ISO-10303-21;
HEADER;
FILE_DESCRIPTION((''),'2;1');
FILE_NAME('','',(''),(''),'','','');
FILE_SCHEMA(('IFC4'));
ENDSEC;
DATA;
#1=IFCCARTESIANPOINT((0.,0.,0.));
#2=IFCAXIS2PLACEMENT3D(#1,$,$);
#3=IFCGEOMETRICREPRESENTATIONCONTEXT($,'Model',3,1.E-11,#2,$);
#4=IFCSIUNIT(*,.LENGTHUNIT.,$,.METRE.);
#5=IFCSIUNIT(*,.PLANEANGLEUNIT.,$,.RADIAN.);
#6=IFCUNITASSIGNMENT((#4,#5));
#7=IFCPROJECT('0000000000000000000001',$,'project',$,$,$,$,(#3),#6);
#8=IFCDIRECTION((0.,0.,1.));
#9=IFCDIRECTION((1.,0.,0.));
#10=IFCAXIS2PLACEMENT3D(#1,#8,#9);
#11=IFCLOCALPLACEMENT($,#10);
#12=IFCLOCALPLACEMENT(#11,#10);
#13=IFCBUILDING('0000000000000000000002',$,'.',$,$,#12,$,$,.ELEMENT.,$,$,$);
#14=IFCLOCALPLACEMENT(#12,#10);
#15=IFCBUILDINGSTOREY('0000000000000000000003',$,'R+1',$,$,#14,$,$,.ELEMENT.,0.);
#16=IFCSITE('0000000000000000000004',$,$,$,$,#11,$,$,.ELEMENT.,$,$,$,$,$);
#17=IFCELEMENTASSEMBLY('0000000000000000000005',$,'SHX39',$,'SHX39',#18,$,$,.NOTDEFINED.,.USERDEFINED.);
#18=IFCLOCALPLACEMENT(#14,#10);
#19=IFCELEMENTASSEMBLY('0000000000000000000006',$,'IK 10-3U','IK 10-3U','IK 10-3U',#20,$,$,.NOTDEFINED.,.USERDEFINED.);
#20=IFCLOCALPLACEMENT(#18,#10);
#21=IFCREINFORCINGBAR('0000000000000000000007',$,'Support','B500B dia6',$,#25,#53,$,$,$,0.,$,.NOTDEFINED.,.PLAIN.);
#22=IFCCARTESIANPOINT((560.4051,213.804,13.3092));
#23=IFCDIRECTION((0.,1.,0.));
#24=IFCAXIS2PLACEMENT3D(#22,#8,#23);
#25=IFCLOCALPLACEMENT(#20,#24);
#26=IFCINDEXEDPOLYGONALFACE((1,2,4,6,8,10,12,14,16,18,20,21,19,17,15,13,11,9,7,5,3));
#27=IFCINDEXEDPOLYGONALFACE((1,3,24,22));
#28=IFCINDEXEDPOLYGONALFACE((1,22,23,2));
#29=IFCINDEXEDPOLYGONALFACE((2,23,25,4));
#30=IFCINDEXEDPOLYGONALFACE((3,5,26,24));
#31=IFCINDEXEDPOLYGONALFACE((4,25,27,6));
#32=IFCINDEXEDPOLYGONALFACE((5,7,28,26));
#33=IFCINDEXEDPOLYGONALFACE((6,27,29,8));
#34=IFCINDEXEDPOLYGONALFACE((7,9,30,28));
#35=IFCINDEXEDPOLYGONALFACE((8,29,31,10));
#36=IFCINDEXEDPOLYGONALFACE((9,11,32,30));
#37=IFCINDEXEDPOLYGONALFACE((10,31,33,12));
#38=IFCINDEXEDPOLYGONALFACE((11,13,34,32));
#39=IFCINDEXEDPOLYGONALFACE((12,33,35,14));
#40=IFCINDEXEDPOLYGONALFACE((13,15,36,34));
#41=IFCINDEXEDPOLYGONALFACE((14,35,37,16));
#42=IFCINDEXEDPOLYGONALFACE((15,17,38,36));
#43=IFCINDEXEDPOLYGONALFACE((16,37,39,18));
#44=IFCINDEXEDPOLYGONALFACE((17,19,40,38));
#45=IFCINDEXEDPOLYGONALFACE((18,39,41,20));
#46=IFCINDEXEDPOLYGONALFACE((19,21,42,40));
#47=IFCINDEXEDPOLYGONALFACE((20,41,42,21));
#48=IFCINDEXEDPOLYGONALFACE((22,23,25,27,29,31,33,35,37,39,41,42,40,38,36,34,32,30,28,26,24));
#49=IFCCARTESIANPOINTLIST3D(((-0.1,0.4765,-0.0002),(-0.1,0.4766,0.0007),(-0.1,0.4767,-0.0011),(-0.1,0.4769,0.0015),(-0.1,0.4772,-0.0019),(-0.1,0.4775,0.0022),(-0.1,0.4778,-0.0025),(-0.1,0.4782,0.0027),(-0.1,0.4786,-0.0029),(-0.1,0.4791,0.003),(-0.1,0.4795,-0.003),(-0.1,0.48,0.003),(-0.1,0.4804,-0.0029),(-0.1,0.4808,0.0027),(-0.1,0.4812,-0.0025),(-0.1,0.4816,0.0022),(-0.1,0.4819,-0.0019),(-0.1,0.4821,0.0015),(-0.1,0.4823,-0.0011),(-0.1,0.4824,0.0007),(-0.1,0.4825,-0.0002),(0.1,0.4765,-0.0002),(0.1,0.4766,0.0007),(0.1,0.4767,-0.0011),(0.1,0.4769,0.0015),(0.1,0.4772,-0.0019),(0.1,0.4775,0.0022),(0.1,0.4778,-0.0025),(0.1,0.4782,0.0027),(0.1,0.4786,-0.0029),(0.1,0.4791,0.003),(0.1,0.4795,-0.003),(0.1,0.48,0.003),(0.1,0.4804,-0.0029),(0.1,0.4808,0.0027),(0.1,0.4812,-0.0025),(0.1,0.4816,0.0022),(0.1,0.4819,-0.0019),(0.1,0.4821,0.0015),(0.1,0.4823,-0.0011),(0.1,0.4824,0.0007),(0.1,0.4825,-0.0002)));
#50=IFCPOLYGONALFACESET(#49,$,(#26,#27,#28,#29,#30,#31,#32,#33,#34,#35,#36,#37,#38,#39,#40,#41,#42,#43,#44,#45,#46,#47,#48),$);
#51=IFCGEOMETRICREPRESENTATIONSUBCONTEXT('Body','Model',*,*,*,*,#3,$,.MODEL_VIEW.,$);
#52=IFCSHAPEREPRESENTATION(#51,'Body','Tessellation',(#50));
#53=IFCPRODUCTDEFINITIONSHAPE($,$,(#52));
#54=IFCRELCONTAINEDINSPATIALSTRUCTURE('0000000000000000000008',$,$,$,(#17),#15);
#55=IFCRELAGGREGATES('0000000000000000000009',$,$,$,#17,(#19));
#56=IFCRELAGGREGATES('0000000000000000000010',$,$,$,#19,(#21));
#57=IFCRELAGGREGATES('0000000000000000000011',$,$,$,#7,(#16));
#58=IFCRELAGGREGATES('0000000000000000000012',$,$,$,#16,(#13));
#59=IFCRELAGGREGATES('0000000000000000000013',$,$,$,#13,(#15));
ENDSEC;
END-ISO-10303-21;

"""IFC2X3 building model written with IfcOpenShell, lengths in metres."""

from ifc_helpers import new_model, entity, si_unit, frame, origin, origin_with_axes, place, context, subcontext, project, spatial, source, transform, mapped, element, aggregate, save


model = new_model("IFC2X3")

# Units and contexts
model_context = context("Model", 3, precision=1e-11, world=origin())
body_context = subcontext(model_context, "Body", "Model", "MODEL_VIEW")
ifc_project = project(units=[si_unit("LENGTHUNIT", "METRE"), si_unit("PLANEANGLEUNIT", "RADIAN")], contexts=[model_context])

# Site, building, storey
site_placement = place(None, origin_with_axes())
site = spatial("IfcSite", under=ifc_project, at=site_placement, CompositionType="ELEMENT")
building_placement = place(site_placement, origin_with_axes())
building = spatial("IfcBuilding", under=site, at=building_placement, Name=".", CompositionType="ELEMENT")
storey_placement = place(building_placement, origin_with_axes())
storey = spatial("IfcBuildingStorey", under=building, at=storey_placement, Name="R+1", CompositionType="ELEMENT", Elevation=0.0)

# Element assemblies, reinforcing bar
assembly_1_placement = place(storey_placement, origin_with_axes())
assembly_1 = element("IfcElementAssembly", 1, at=assembly_1_placement, inside=storey, Name="SHX39", ObjectType="SHX39", AssemblyPlace="NOTDEFINED", PredefinedType="USERDEFINED")
assembly_2_placement = place(assembly_1_placement, origin_with_axes())
assembly_2 = element("IfcElementAssembly", 2, at=assembly_2_placement, Name="IK 10-3U", Description="IK 10-3U", ObjectType="IK 10-3U", AssemblyPlace="NOTDEFINED", PredefinedType="USERDEFINED")
aggregate(assembly_1, [assembly_2])
shared_shape_1 = source(origin_with_axes(), body_context, "Body", "AdvancedSweptSolid", [
    entity("IfcSweptDiskSolid", entity("IfcPolyline", [entity("IfcCartesianPoint", [0.1, 0.4795, 0.0]), entity("IfcCartesianPoint", [-0.1, 0.4795, 0.0])]), 0.003, None, 0.0, 0.2),
])
reinforcing_bar_1_placement = place(assembly_2_placement, frame((560.4051, 213.804, 13.3092), z_axis=(0.0, 0.0, 1.0), x_axis=(0.0, 1.0, 0.0)))
reinforcing_bar_1 = element("IfcReinforcingBar", 3, at=reinforcing_bar_1_placement, Name="Support", Description="B500B dia6", BarRole="NOTDEFINED", BarSurface="PLAIN", CrossSectionArea=0.0, context=body_context, shape_type="MappedRepresentation", body=[
    mapped(shared_shape_1, transform((0.0, 0.0, 0.0), scale=1.0)),
])
aggregate(assembly_2, [reinforcing_bar_1])

save(model, "model.ifc")
